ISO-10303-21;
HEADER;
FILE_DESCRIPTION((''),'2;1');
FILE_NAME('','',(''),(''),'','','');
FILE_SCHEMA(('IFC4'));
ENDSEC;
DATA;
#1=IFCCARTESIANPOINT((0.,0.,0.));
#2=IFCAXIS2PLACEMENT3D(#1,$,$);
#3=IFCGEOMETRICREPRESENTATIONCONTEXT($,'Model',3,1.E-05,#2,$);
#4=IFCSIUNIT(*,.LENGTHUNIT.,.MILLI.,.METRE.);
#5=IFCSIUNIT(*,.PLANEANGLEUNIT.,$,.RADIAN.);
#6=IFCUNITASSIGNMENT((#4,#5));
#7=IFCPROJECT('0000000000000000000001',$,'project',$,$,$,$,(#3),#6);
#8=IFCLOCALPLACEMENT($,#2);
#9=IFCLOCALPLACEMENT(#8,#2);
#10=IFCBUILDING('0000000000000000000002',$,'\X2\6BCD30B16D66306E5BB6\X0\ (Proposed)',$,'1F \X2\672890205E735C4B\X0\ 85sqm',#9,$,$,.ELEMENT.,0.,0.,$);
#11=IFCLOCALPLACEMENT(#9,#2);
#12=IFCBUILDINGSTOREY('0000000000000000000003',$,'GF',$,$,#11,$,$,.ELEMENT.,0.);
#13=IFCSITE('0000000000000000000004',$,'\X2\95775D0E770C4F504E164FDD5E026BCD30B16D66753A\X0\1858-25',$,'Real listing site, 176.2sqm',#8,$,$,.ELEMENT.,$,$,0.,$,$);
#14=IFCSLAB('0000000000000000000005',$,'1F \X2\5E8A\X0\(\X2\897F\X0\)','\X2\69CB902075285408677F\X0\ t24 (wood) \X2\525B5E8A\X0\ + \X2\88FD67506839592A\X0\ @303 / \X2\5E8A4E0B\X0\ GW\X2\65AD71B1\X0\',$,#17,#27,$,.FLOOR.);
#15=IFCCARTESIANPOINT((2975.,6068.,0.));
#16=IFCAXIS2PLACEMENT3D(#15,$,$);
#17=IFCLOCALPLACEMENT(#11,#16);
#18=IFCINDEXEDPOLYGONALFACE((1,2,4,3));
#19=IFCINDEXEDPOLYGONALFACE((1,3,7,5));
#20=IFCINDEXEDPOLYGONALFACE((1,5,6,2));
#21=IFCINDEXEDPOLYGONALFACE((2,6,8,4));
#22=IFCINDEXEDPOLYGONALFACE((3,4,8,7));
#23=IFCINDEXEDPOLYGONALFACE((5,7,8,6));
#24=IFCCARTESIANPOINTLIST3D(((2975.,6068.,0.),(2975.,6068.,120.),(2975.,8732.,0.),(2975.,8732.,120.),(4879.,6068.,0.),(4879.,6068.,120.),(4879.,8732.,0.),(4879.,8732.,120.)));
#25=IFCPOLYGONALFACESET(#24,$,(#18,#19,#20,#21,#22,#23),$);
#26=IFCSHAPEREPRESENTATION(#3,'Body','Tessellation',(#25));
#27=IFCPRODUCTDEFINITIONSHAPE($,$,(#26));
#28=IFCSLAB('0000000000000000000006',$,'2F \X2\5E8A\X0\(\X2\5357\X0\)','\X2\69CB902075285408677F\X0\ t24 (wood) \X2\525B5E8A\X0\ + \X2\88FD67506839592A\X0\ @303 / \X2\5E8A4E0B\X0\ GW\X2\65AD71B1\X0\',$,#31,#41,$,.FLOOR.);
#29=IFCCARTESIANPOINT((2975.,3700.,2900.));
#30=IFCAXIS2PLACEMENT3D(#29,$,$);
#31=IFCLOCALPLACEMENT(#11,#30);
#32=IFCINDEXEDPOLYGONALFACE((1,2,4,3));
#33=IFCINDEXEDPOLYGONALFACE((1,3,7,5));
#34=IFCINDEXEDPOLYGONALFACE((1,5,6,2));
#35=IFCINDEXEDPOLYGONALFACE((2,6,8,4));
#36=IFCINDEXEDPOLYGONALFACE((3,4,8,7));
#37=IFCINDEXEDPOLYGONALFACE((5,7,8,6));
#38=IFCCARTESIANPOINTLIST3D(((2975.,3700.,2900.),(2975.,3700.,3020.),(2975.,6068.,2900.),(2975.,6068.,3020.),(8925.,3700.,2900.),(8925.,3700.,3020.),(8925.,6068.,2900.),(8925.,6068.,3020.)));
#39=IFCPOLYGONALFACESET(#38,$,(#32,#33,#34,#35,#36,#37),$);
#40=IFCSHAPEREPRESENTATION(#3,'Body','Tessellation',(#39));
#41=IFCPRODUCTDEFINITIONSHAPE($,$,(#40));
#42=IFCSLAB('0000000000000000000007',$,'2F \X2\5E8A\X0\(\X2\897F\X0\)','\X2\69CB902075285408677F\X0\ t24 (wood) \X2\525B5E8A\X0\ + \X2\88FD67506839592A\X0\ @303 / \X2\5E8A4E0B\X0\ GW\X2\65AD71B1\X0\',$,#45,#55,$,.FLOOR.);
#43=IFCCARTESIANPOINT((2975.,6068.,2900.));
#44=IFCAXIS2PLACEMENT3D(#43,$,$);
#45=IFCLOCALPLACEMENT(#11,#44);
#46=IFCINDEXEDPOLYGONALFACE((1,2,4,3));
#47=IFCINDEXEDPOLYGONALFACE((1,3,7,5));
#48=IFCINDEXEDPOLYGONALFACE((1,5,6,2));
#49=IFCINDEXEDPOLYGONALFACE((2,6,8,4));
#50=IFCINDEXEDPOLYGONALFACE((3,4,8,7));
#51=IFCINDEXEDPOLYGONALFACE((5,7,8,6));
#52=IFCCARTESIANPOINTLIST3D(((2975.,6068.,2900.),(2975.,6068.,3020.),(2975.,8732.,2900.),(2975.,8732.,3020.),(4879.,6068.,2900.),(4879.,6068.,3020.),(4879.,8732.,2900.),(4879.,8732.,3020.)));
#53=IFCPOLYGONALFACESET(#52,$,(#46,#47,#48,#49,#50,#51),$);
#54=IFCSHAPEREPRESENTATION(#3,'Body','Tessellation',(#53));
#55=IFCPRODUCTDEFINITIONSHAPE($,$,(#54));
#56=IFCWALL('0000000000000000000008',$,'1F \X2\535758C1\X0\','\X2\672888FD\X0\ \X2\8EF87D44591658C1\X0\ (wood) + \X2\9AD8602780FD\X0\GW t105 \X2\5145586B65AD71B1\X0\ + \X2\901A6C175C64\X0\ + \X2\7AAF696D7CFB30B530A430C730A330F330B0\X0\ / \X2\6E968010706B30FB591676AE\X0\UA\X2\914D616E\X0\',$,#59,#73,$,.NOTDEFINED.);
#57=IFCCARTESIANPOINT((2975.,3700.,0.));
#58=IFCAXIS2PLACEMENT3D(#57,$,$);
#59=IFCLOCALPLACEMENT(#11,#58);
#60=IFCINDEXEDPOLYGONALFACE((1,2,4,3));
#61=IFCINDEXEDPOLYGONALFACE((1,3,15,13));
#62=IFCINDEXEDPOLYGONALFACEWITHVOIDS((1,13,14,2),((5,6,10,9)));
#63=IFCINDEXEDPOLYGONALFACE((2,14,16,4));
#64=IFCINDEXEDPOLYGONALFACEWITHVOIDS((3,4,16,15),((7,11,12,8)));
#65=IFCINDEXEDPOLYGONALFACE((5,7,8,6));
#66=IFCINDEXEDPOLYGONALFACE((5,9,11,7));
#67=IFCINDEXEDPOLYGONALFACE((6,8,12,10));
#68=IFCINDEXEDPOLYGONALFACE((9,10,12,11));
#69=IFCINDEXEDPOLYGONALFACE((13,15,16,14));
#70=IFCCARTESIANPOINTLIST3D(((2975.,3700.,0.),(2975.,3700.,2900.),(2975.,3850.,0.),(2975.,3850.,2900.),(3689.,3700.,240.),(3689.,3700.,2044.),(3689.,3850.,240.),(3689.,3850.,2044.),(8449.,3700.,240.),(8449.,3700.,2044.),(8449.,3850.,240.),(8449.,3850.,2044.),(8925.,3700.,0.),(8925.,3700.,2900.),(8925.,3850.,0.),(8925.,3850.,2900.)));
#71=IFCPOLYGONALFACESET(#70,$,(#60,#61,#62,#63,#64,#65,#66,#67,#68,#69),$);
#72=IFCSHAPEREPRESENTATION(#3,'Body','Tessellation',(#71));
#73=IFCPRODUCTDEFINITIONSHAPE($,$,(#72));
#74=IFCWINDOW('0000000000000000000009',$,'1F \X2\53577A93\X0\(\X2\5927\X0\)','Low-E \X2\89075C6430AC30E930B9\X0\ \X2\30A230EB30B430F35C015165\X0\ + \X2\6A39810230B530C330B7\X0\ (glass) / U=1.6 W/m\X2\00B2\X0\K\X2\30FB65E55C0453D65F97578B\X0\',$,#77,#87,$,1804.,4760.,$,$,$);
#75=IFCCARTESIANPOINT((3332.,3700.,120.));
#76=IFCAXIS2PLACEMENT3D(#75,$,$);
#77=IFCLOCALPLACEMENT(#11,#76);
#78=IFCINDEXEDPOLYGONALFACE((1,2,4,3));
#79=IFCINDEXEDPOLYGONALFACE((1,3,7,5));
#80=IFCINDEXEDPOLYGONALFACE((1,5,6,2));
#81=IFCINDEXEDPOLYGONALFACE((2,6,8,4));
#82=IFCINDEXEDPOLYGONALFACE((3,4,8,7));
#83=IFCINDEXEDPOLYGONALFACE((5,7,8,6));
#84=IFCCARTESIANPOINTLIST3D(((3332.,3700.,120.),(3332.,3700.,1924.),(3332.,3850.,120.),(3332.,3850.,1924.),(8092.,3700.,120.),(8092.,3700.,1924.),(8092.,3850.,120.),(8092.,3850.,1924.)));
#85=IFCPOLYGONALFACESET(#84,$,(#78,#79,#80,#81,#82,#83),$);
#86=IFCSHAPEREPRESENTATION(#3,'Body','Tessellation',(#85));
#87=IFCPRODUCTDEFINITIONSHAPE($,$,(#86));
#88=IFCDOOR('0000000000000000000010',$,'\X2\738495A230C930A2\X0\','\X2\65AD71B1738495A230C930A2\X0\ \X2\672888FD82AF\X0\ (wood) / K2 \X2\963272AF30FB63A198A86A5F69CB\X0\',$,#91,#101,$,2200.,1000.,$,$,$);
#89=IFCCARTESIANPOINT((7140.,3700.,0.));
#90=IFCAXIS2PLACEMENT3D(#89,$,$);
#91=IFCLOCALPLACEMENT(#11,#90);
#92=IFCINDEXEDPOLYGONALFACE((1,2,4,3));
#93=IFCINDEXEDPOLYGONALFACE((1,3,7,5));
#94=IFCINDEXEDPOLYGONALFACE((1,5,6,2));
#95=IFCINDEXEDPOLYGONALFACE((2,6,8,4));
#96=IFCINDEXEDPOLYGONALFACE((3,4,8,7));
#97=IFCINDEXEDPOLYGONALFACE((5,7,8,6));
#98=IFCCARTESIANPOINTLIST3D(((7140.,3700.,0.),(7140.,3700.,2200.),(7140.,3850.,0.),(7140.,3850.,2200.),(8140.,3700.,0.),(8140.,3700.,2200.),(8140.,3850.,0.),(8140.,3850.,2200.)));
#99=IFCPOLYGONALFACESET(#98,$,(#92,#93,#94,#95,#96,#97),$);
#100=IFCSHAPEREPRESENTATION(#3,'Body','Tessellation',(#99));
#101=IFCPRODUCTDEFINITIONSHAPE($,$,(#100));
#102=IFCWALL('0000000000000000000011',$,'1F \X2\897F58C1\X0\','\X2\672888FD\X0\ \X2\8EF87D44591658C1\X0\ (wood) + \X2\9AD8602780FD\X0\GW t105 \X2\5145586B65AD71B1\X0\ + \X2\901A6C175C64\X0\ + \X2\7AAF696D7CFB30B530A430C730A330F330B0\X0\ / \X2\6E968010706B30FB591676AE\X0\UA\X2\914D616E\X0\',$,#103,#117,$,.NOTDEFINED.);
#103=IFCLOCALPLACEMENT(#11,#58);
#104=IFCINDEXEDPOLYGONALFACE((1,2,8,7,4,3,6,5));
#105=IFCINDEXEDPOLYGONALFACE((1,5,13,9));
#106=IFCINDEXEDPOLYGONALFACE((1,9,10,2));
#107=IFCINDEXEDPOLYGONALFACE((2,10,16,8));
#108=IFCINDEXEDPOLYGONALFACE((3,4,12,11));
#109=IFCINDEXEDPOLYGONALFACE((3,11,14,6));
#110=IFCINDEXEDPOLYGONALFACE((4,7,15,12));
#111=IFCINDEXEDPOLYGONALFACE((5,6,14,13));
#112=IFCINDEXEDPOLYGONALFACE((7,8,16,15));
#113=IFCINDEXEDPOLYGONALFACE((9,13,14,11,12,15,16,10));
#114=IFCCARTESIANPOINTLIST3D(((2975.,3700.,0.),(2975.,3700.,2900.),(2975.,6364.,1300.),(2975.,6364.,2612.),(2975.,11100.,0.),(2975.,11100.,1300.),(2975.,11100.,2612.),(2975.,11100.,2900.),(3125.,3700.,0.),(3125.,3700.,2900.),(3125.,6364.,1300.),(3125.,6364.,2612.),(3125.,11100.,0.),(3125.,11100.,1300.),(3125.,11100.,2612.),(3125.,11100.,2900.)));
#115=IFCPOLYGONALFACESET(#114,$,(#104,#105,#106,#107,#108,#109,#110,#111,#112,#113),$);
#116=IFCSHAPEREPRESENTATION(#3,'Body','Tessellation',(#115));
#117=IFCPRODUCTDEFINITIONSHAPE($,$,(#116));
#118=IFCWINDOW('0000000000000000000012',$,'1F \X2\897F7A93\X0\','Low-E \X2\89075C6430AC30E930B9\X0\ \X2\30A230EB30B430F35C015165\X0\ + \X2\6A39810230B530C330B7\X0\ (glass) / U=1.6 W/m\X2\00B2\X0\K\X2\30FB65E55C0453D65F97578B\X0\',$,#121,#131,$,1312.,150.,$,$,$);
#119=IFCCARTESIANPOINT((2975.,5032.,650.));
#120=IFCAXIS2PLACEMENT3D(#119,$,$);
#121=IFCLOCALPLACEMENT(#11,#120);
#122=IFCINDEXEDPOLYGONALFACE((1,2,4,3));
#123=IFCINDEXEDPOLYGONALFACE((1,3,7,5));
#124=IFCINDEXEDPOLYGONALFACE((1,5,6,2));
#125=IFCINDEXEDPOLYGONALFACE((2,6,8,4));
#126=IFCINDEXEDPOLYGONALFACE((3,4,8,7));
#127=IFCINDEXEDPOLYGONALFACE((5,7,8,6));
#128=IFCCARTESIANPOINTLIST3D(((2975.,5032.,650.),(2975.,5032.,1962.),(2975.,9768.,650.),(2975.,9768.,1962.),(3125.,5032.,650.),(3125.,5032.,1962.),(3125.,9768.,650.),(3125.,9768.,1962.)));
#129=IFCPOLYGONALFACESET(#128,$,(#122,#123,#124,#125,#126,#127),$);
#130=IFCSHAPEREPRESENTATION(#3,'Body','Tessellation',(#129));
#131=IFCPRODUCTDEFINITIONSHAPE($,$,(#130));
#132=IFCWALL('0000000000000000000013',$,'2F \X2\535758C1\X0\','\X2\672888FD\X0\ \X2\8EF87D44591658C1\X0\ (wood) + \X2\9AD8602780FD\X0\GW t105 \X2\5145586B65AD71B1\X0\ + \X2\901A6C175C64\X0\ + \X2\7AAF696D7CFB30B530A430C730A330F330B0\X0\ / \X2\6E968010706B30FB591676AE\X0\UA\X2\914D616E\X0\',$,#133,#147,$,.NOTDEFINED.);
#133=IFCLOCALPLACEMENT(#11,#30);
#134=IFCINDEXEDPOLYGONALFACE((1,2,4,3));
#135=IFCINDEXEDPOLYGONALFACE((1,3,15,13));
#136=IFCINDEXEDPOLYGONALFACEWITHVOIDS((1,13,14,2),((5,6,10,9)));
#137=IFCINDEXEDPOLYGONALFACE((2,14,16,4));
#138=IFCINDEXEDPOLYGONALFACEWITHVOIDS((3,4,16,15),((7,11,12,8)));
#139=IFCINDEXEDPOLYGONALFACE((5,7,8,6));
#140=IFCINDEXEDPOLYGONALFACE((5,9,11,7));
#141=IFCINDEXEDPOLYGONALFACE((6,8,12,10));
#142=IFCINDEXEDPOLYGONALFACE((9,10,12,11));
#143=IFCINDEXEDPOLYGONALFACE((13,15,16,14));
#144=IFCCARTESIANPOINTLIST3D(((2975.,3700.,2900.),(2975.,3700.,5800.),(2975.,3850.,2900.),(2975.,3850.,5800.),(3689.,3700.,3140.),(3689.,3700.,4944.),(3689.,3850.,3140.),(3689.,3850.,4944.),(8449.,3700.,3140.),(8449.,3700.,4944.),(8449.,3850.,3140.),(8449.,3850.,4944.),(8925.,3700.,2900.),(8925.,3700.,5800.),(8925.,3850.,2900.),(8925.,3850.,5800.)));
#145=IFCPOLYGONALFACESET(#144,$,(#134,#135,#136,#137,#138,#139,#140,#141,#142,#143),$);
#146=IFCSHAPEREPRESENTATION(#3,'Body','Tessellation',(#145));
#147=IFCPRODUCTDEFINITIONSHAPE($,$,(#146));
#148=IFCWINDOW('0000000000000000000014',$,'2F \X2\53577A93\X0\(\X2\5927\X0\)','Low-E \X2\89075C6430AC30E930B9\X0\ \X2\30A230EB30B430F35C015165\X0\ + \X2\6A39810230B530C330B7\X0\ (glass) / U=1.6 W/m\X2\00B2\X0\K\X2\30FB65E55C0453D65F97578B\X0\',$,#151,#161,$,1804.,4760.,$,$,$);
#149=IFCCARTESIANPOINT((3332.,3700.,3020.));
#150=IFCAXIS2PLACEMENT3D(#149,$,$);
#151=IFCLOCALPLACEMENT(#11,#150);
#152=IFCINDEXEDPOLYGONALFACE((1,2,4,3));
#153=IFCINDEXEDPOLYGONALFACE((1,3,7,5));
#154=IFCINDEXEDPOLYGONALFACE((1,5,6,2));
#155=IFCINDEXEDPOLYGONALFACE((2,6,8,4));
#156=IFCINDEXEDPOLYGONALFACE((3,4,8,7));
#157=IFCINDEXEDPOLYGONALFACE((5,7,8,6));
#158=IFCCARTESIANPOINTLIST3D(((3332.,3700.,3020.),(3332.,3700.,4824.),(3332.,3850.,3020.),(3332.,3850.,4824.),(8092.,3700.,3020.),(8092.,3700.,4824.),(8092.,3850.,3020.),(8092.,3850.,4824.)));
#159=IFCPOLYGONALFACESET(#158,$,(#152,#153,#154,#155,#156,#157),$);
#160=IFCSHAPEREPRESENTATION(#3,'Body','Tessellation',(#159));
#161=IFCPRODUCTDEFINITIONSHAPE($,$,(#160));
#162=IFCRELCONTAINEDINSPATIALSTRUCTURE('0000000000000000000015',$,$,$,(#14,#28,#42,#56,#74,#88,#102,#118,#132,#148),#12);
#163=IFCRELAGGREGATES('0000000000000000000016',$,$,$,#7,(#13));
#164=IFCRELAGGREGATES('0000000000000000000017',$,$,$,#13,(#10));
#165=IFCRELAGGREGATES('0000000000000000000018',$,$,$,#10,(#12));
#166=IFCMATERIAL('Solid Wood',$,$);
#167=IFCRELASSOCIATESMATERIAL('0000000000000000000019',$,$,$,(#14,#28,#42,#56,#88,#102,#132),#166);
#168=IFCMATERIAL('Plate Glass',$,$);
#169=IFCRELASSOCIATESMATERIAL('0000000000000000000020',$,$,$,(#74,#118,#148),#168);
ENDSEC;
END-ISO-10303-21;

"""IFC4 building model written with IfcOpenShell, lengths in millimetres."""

from ifc_helpers import new_model, si_unit, frame, frame_2d, origin, place, context, project, spatial, rectangle, extrude, material, element, fill, save


model = new_model("IFC4")

# Units and contexts
model_context = context("Model", 3, precision=1e-05, world=origin())
ifc_project = project(units=[si_unit("LENGTHUNIT", "METRE", prefix="MILLI"), si_unit("PLANEANGLEUNIT", "RADIAN")], contexts=[model_context])

# Site, building, storey
site_placement = place(None, origin())
site = spatial("IfcSite", under=ifc_project, at=site_placement, Name="長崎県佐世保市母ケ浦町1858-25", ObjectType="Real listing site, 176.2sqm", CompositionType="ELEMENT", RefElevation=0.0)
building_placement = place(site_placement, origin())
building = spatial("IfcBuilding", under=site, at=building_placement, Name="母ケ浦の家 (Proposed)", ObjectType="1F 木造平屋 85sqm", CompositionType="ELEMENT", ElevationOfRefHeight=0.0, ElevationOfTerrain=0.0)
storey_placement = place(building_placement, origin())
storey = spatial("IfcBuildingStorey", under=building, at=storey_placement, Name="GF", CompositionType="ELEMENT", Elevation=0.0)

# Slabs
ifc_material_1 = material(Name="Solid Wood")
slab_1_placement = place(storey_placement, frame((2975.0, 6068.0, 0.0)))
element("IfcSlab", 1, at=slab_1_placement, inside=storey, material=ifc_material_1, Name="1F 床(西)", Description="構造用合板 t24 (wood) 剛床 + 製材根太 @303 / 床下 GW断熱", PredefinedType="FLOOR", context=model_context, shape_type="SweptSolid", body=[
    extrude(rectangle(XDim=1904.0, YDim=2664.0, at=frame_2d((952.0, 1332.0))), frame((2975.0, 6068.0, 0.0)), (0.0, 0.0, 1.0), 120.0),
])
slab_2_placement = place(storey_placement, frame((2975.0, 3700.0, 2900.0)))
element("IfcSlab", 2, at=slab_2_placement, inside=storey, material=ifc_material_1, Name="2F 床(南)", Description="構造用合板 t24 (wood) 剛床 + 製材根太 @303 / 床下 GW断熱", PredefinedType="FLOOR", context=model_context, shape_type="SweptSolid", body=[
    extrude(rectangle(XDim=5950.0, YDim=2368.0, at=frame_2d((2975.0, 1184.0))), frame((2975.0, 3700.0, 2900.0)), (0.0, 0.0, 1.0), 120.0),
])
slab_3_placement = place(storey_placement, frame((2975.0, 6068.0, 2900.0)))
element("IfcSlab", 3, at=slab_3_placement, inside=storey, material=ifc_material_1, Name="2F 床(西)", Description="構造用合板 t24 (wood) 剛床 + 製材根太 @303 / 床下 GW断熱", PredefinedType="FLOOR", context=model_context, shape_type="SweptSolid", body=[
    extrude(rectangle(XDim=1904.0, YDim=2664.0, at=frame_2d((952.0, 1332.0))), frame((2975.0, 6068.0, 2900.0)), (0.0, 0.0, 1.0), 120.0),
])

# Wall, openings, window, door
wall_1_placement = place(storey_placement, frame((2975.0, 3700.0, 0.0)))
wall_1 = element("IfcWall", 4, at=wall_1_placement, inside=storey, material=ifc_material_1, Name="1F 南壁", Description="木製 軸組外壁 (wood) + 高性能GW t105 充填断熱 + 通気層 + 窯業系サイディング / 準耐火・外皮UA配慮", PredefinedType="NOTDEFINED", context=model_context, shape_type="SweptSolid", body=[
    extrude(rectangle(XDim=5950.0, YDim=150.0, at=frame_2d((2975.0, 75.0))), frame((2975.0, 3700.0, 0.0)), (0.0, 0.0, 1.0), 2900.0),
])
opening_1_placement = place(storey_placement, frame((3332.0, 3700.0, 120.0)))
opening_1 = element("IfcOpeningElement", 5, at=opening_1_placement, cuts=wall_1, PredefinedType="NOTDEFINED", context=model_context, shape_type="SweptSolid", body=[
    extrude(rectangle(XDim=4760.0, YDim=150.0, at=frame_2d((2380.0, 75.0))), frame((3332.0, 3700.0, 120.0)), (0.0, 0.0, 1.0), 1804.0),
])
opening_2_placement = place(storey_placement, frame((7140.0, 3700.0, 0.0)))
opening_2 = element("IfcOpeningElement", 6, at=opening_2_placement, cuts=wall_1, PredefinedType="NOTDEFINED", context=model_context, shape_type="SweptSolid", body=[
    extrude(rectangle(XDim=1000.0, YDim=150.0, at=frame_2d((500.0, 75.0))), frame((7140.0, 3700.0, 0.0)), (0.0, 0.0, 1.0), 2200.0),
])
ifc_material_2 = material(Name="Plate Glass")
window_1_placement = place(storey_placement, frame((3332.0, 3700.0, 120.0)))
window_1 = element("IfcWindow", 7, at=window_1_placement, inside=storey, material=ifc_material_2, Name="1F 南窓(大)", Description="Low-E 複層ガラス アルゴン封入 + 樹脂サッシ (glass) / U=1.6 W/m²K・日射取得型", OverallHeight=1804.0, OverallWidth=4760.0, context=model_context, shape_type="SweptSolid", body=[
    extrude(rectangle(XDim=4760.0, YDim=150.0, at=frame_2d((2380.0, 75.0))), frame((3332.0, 3700.0, 120.0)), (0.0, 0.0, 1.0), 1804.0),
])
fill(opening_1, window_1)
door_placement = place(storey_placement, frame((7140.0, 3700.0, 0.0)))
door = element("IfcDoor", 8, at=door_placement, inside=storey, material=ifc_material_1, Name="玄関ドア", Description="断熱玄関ドア 木製芯 (wood) / K2 防犯・採風機構", OverallHeight=2200.0, OverallWidth=1000.0, context=model_context, shape_type="SweptSolid", body=[
    extrude(rectangle(XDim=1000.0, YDim=150.0, at=frame_2d((500.0, 75.0))), frame((7140.0, 3700.0, 0.0)), (0.0, 0.0, 1.0), 2200.0),
])
fill(opening_2, door)

# Walls, openings, windows
wall_2_placement = place(storey_placement, frame((2975.0, 3700.0, 0.0)))
wall_2 = element("IfcWall", 9, at=wall_2_placement, inside=storey, material=ifc_material_1, Name="1F 西壁", Description="木製 軸組外壁 (wood) + 高性能GW t105 充填断熱 + 通気層 + 窯業系サイディング / 準耐火・外皮UA配慮", PredefinedType="NOTDEFINED", context=model_context, shape_type="SweptSolid", body=[
    extrude(rectangle(XDim=150.0, YDim=7400.0, at=frame_2d((75.0, 3700.0))), frame((2975.0, 3700.0, 0.0)), (0.0, 0.0, 1.0), 2900.0),
])
opening_3_placement = place(storey_placement, frame((2975.0, 5032.0, 650.0)))
opening_3 = element("IfcOpeningElement", 10, at=opening_3_placement, cuts=wall_2, PredefinedType="NOTDEFINED", context=model_context, shape_type="SweptSolid", body=[
    extrude(rectangle(XDim=150.0, YDim=4736.0, at=frame_2d((75.0, 2368.0))), frame((2975.0, 5032.0, 650.0)), (0.0, 0.0, 1.0), 1312.0),
])
window_2_placement = place(storey_placement, frame((2975.0, 5032.0, 650.0)))
window_2 = element("IfcWindow", 11, at=window_2_placement, inside=storey, material=ifc_material_2, Name="1F 西窓", Description="Low-E 複層ガラス アルゴン封入 + 樹脂サッシ (glass) / U=1.6 W/m²K・日射取得型", OverallHeight=1312.0, OverallWidth=150.0, context=model_context, shape_type="SweptSolid", body=[
    extrude(rectangle(XDim=150.0, YDim=4736.0, at=frame_2d((75.0, 2368.0))), frame((2975.0, 5032.0, 650.0)), (0.0, 0.0, 1.0), 1312.0),
])
fill(opening_3, window_2)
wall_3_placement = place(storey_placement, frame((2975.0, 3700.0, 2900.0)))
wall_3 = element("IfcWall", 12, at=wall_3_placement, inside=storey, material=ifc_material_1, Name="2F 南壁", Description="木製 軸組外壁 (wood) + 高性能GW t105 充填断熱 + 通気層 + 窯業系サイディング / 準耐火・外皮UA配慮", PredefinedType="NOTDEFINED", context=model_context, shape_type="SweptSolid", body=[
    extrude(rectangle(XDim=5950.0, YDim=150.0, at=frame_2d((2975.0, 75.0))), frame((2975.0, 3700.0, 2900.0)), (0.0, 0.0, 1.0), 2900.0),
])
opening_4_placement = place(storey_placement, frame((3332.0, 3700.0, 3020.0)))
opening_4 = element("IfcOpeningElement", 13, at=opening_4_placement, cuts=wall_3, PredefinedType="NOTDEFINED", context=model_context, shape_type="SweptSolid", body=[
    extrude(rectangle(XDim=4760.0, YDim=150.0, at=frame_2d((2380.0, 75.0))), frame((3332.0, 3700.0, 3020.0)), (0.0, 0.0, 1.0), 1804.0),
])
window_3_placement = place(storey_placement, frame((3332.0, 3700.0, 3020.0)))
window_3 = element("IfcWindow", 14, at=window_3_placement, inside=storey, material=ifc_material_2, Name="2F 南窓(大)", Description="Low-E 複層ガラス アルゴン封入 + 樹脂サッシ (glass) / U=1.6 W/m²K・日射取得型", OverallHeight=1804.0, OverallWidth=4760.0, context=model_context, shape_type="SweptSolid", body=[
    extrude(rectangle(XDim=4760.0, YDim=150.0, at=frame_2d((2380.0, 75.0))), frame((3332.0, 3700.0, 3020.0)), (0.0, 0.0, 1.0), 1804.0),
])
fill(opening_4, window_3)

save(model, "model.ifc")
